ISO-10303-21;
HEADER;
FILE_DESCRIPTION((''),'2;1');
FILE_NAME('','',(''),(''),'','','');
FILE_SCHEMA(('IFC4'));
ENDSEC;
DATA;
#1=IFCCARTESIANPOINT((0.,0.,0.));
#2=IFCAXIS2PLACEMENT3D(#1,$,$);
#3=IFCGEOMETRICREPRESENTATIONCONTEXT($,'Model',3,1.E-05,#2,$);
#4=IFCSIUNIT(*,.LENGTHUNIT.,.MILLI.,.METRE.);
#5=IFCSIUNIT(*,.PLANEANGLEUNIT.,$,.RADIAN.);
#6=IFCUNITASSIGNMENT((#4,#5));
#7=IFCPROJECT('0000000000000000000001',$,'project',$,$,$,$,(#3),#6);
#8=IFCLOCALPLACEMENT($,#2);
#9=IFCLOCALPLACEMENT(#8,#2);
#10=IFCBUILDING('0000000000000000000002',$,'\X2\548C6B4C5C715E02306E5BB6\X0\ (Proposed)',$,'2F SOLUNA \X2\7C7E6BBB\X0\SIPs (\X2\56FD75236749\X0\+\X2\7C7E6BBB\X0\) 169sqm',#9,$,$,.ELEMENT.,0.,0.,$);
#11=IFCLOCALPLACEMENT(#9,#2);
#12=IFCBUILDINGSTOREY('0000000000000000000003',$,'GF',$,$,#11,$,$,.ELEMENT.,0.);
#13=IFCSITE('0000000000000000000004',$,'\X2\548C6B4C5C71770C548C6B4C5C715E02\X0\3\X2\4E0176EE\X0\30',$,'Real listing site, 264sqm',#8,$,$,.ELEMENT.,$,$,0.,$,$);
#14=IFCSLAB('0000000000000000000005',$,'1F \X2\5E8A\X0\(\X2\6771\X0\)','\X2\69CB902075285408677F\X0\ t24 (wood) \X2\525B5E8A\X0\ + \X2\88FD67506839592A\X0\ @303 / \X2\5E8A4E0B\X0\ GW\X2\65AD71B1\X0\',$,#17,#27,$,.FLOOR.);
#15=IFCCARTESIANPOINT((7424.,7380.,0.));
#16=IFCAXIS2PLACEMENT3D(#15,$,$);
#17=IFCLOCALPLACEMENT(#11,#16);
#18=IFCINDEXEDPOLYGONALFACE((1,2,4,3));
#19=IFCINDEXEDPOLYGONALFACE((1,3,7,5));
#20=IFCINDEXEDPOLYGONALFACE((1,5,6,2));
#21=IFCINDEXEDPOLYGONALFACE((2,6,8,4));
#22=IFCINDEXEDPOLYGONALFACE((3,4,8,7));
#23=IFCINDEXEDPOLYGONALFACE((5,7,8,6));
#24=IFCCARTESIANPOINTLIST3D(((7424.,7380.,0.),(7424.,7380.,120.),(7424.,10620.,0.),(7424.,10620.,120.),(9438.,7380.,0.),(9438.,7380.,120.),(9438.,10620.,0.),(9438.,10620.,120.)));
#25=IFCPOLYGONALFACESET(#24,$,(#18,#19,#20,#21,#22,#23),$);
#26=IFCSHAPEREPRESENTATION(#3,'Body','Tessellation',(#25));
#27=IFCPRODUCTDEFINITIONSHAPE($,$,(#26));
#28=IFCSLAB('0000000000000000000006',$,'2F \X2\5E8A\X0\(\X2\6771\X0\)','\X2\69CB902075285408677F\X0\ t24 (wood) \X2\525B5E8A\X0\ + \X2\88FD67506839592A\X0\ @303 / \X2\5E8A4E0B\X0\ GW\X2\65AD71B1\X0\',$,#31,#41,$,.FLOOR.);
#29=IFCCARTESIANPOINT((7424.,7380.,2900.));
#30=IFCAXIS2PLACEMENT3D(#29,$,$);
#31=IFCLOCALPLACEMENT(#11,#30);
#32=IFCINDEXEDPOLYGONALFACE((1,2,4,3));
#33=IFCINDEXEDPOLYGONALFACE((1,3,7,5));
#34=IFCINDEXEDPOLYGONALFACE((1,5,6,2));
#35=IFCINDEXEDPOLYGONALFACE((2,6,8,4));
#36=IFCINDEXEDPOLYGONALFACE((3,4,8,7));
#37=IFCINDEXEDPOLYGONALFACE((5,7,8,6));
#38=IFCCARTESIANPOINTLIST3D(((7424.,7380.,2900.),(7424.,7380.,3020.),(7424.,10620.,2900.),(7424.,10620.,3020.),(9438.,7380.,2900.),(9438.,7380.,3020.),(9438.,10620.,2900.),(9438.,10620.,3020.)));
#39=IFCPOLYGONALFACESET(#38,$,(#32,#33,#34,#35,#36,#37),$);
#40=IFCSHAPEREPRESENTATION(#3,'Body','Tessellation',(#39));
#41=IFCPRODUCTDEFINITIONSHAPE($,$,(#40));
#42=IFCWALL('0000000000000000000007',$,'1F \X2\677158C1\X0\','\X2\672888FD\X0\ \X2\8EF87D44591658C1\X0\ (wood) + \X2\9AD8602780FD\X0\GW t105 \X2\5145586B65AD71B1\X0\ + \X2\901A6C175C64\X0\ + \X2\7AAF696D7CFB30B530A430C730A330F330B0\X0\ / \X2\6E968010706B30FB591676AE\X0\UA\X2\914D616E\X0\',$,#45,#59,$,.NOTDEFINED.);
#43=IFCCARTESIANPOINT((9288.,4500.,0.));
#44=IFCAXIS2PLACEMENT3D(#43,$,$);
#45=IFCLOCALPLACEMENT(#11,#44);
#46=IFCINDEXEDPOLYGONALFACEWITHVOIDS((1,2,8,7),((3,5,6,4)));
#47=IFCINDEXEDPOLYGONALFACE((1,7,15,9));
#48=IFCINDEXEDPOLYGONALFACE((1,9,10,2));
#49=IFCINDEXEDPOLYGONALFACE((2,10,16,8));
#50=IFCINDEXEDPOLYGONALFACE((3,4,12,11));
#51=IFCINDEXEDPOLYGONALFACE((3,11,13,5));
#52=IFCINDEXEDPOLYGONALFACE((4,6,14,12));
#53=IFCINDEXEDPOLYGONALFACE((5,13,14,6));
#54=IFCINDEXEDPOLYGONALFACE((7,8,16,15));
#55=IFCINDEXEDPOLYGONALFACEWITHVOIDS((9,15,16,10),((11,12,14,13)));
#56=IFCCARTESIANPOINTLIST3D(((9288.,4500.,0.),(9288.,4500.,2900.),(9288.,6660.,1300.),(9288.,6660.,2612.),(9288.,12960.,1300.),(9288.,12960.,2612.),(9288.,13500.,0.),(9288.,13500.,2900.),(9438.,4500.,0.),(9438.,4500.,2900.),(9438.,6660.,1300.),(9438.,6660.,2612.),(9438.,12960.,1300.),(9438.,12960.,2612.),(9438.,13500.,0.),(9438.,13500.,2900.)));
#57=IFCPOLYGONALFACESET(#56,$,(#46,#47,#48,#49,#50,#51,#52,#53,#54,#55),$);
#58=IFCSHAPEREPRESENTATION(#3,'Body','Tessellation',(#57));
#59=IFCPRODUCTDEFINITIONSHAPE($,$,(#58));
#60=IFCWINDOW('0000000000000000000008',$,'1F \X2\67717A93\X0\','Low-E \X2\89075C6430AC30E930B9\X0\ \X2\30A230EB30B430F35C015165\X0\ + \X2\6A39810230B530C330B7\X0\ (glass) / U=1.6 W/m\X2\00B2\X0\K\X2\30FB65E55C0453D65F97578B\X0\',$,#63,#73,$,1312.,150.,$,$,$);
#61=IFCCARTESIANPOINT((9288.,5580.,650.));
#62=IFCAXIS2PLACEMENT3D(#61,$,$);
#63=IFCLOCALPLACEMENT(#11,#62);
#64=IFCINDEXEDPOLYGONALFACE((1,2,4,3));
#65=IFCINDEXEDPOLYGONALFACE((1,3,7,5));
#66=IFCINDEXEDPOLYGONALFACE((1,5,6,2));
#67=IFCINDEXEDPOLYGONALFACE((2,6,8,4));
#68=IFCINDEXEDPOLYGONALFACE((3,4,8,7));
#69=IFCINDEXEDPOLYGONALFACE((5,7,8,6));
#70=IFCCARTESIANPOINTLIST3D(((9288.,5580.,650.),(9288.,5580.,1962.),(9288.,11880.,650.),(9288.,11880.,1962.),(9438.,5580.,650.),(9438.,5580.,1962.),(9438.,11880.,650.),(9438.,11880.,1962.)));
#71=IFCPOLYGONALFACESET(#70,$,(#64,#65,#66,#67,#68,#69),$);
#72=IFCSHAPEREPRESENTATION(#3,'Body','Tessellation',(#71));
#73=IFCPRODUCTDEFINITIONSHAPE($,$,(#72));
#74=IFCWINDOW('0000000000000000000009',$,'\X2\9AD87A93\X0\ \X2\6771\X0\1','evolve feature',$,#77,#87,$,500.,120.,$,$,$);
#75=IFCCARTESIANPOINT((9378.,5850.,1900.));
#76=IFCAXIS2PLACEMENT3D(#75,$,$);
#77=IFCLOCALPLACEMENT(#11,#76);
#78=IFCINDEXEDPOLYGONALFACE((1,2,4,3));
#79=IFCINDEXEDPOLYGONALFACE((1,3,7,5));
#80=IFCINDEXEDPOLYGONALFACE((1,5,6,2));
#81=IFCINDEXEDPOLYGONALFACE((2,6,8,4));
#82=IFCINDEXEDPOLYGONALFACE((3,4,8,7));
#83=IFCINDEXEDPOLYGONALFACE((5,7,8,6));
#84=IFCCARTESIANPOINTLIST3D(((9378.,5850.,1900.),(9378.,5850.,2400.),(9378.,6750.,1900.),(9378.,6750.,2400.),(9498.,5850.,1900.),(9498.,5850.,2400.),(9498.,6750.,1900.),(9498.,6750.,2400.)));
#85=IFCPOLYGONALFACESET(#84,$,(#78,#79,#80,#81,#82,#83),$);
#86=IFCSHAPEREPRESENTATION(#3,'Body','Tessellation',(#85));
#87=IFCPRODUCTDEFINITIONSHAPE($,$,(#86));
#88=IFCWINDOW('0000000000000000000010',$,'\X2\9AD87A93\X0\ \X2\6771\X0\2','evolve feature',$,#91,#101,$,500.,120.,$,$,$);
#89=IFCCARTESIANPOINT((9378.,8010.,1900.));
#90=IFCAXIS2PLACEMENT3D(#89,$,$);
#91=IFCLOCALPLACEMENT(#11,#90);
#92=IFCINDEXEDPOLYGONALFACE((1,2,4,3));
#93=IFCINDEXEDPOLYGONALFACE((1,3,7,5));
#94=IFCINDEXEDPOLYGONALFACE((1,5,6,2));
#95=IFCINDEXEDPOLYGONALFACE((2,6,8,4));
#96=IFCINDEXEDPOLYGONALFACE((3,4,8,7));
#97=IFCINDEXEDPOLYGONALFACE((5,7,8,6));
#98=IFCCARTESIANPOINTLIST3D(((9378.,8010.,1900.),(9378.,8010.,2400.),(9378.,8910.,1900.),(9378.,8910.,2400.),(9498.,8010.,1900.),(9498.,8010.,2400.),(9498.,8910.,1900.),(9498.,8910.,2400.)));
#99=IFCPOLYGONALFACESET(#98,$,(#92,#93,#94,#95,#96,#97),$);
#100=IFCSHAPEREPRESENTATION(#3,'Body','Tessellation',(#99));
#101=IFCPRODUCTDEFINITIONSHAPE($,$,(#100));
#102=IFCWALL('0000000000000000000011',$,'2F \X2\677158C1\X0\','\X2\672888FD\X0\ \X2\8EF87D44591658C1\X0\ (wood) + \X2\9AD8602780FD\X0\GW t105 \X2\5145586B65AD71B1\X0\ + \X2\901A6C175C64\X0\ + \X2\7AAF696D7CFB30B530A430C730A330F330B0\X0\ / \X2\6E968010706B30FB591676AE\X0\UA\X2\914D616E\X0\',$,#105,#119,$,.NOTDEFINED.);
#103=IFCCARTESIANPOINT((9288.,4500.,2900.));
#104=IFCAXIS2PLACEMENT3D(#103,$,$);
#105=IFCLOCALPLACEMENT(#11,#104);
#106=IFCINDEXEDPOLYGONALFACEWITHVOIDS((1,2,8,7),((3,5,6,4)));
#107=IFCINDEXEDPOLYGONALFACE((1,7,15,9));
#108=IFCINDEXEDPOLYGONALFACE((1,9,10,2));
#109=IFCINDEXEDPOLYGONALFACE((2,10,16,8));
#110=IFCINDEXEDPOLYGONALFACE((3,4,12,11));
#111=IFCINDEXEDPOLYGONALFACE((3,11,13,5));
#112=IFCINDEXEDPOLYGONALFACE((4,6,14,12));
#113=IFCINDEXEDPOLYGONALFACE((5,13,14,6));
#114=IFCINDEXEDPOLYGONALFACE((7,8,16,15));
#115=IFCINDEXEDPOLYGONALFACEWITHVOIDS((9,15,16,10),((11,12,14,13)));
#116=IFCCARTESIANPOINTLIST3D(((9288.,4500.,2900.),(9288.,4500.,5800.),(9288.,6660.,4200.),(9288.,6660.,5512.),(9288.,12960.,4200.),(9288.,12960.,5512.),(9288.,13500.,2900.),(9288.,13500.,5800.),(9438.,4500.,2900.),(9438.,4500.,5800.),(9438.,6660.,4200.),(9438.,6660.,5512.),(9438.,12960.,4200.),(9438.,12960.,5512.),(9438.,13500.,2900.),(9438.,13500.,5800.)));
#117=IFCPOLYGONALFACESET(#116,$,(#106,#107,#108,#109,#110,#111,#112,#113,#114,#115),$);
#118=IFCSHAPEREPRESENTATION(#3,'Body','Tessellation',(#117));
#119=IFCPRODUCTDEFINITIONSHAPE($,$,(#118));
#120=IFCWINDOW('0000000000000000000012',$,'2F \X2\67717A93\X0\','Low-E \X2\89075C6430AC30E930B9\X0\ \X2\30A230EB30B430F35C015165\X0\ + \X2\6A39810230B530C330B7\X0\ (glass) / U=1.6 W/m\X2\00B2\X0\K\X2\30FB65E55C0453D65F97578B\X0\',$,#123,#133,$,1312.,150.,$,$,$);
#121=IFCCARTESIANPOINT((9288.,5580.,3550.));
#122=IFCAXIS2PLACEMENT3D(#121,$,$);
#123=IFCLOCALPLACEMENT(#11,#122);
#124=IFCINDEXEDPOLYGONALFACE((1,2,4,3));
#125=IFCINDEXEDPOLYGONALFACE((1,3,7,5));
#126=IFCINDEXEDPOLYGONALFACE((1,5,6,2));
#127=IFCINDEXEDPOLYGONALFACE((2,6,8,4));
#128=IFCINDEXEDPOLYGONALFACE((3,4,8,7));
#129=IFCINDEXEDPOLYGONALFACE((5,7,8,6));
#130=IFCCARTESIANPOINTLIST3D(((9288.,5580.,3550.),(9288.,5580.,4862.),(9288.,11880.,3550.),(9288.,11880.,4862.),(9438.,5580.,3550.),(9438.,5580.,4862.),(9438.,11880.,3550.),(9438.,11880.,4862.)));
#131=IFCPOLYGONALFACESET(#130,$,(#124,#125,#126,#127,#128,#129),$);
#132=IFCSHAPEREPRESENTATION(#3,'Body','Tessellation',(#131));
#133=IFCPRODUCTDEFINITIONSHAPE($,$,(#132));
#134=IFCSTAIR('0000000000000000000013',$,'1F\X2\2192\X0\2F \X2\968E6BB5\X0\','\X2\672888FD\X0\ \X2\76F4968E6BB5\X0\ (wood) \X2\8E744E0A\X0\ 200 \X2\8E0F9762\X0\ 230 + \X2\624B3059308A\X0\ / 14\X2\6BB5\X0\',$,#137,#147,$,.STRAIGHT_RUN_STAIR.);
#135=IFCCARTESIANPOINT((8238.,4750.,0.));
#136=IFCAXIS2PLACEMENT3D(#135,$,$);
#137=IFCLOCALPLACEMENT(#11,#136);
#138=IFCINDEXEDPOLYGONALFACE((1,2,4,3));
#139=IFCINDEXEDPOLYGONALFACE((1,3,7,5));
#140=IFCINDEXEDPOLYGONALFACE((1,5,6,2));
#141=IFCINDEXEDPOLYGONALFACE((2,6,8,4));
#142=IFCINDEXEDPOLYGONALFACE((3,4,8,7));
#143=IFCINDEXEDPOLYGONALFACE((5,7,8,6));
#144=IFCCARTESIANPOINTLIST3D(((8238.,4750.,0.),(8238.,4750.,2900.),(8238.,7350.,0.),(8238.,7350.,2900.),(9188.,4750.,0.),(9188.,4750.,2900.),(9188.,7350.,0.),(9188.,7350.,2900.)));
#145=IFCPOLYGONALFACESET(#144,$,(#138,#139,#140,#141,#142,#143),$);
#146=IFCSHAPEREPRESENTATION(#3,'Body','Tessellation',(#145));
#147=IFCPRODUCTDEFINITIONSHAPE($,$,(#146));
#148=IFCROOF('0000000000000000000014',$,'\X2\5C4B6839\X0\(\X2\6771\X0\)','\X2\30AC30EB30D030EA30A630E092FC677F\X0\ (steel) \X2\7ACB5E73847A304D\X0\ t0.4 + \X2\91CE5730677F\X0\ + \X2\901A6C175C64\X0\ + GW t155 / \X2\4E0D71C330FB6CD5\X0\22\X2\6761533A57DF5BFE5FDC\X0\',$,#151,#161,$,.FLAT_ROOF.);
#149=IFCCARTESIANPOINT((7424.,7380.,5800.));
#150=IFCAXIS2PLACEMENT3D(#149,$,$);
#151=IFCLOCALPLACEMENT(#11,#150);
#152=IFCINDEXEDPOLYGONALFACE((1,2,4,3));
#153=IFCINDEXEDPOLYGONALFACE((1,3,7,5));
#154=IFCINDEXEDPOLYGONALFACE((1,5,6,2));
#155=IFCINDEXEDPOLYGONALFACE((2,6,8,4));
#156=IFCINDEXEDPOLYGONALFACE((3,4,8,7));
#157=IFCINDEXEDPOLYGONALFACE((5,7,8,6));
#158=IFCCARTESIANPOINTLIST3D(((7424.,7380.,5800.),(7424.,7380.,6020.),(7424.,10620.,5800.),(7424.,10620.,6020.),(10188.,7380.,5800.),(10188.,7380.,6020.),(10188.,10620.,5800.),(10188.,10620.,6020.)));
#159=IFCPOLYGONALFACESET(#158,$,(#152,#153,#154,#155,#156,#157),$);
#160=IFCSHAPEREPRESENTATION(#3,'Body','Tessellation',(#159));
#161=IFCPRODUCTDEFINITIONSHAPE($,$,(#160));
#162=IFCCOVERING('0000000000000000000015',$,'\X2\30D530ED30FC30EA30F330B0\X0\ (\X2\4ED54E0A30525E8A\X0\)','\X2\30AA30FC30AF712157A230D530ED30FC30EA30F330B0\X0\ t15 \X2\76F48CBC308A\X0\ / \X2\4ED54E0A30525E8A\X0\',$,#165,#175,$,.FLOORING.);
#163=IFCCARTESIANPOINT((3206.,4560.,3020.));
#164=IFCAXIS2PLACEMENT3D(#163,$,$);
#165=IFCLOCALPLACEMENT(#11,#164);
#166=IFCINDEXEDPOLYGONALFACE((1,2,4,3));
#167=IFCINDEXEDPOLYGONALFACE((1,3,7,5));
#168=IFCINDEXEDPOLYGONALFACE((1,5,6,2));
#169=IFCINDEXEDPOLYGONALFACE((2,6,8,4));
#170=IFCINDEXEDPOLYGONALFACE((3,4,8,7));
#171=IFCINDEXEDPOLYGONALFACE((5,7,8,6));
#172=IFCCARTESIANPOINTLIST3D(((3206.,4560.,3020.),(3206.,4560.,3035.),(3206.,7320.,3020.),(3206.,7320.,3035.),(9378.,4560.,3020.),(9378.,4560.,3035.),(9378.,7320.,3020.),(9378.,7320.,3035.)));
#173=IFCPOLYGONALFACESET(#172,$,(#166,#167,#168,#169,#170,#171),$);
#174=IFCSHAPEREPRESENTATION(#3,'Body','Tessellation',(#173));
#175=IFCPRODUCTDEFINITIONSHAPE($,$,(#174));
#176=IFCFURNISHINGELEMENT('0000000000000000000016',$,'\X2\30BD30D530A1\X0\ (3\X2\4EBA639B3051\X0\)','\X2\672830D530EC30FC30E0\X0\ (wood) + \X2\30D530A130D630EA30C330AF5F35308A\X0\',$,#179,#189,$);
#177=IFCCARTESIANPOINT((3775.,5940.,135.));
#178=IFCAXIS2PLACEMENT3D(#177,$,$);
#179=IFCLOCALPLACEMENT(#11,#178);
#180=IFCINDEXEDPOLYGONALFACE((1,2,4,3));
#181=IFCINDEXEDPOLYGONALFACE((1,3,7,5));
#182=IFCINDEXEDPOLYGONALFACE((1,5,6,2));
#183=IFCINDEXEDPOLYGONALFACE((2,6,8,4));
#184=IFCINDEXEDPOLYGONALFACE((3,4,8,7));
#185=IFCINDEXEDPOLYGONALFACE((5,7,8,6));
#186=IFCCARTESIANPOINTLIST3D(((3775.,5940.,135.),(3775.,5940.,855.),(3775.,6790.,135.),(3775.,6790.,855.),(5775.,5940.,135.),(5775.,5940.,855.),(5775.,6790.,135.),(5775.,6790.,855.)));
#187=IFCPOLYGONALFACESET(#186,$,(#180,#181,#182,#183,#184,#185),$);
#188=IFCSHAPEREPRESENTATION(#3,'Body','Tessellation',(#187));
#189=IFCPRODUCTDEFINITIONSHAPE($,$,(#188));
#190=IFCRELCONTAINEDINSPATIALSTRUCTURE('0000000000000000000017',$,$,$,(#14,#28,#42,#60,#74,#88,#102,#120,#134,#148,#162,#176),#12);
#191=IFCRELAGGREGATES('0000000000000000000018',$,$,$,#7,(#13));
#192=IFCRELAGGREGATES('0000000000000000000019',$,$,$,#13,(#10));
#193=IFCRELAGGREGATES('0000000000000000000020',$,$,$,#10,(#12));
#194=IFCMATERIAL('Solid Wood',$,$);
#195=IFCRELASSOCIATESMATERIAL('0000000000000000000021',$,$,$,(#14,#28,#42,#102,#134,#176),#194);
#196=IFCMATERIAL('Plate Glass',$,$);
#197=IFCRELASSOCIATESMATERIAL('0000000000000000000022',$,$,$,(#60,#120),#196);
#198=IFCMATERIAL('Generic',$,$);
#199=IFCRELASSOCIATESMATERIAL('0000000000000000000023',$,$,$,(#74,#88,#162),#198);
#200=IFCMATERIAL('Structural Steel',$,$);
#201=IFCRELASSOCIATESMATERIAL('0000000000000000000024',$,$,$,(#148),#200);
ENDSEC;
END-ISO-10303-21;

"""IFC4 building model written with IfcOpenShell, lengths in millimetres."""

from ifc_helpers import new_model, si_unit, frame, frame_2d, origin, place, context, project, spatial, rectangle, extrude, material, element, fill, save


model = new_model("IFC4")

# Units and contexts
model_context = context("Model", 3, precision=1e-05, world=origin())
ifc_project = project(units=[si_unit("LENGTHUNIT", "METRE", prefix="MILLI"), si_unit("PLANEANGLEUNIT", "RADIAN")], contexts=[model_context])

# Site, building, storey
site_placement = place(None, origin())
site = spatial("IfcSite", under=ifc_project, at=site_placement, Name="和歌山県和歌山市3丁目30", ObjectType="Real listing site, 264sqm", CompositionType="ELEMENT", RefElevation=0.0)
building_placement = place(site_placement, origin())
building = spatial("IfcBuilding", under=site, at=building_placement, Name="和歌山市の家 (Proposed)", ObjectType="2F SOLUNA 籾殻SIPs (国産杉+籾殻) 169sqm", CompositionType="ELEMENT", ElevationOfRefHeight=0.0, ElevationOfTerrain=0.0)
storey_placement = place(building_placement, origin())
storey = spatial("IfcBuildingStorey", under=building, at=storey_placement, Name="GF", CompositionType="ELEMENT", Elevation=0.0)

# Slabs
ifc_material_1 = material(Name="Solid Wood")
slab_1_placement = place(storey_placement, frame((7424.0, 7380.0, 0.0)))
element("IfcSlab", 1, at=slab_1_placement, inside=storey, material=ifc_material_1, Name="1F 床(東)", Description="構造用合板 t24 (wood) 剛床 + 製材根太 @303 / 床下 GW断熱", PredefinedType="FLOOR", context=model_context, shape_type="SweptSolid", body=[
    extrude(rectangle(XDim=2014.0, YDim=3240.0, at=frame_2d((1007.0, 1620.0))), frame((7424.0, 7380.0, 0.0)), (0.0, 0.0, 1.0), 120.0),
])
slab_2_placement = place(storey_placement, frame((7424.0, 7380.0, 2900.0)))
element("IfcSlab", 2, at=slab_2_placement, inside=storey, material=ifc_material_1, Name="2F 床(東)", Description="構造用合板 t24 (wood) 剛床 + 製材根太 @303 / 床下 GW断熱", PredefinedType="FLOOR", context=model_context, shape_type="SweptSolid", body=[
    extrude(rectangle(XDim=2014.0, YDim=3240.0, at=frame_2d((1007.0, 1620.0))), frame((7424.0, 7380.0, 2900.0)), (0.0, 0.0, 1.0), 120.0),
])

# Wall, openings, windows
wall_1_placement = place(storey_placement, frame((9288.0, 4500.0, 0.0)))
wall_1 = element("IfcWall", 3, at=wall_1_placement, inside=storey, material=ifc_material_1, Name="1F 東壁", Description="木製 軸組外壁 (wood) + 高性能GW t105 充填断熱 + 通気層 + 窯業系サイディング / 準耐火・外皮UA配慮", PredefinedType="NOTDEFINED", context=model_context, shape_type="SweptSolid", body=[
    extrude(rectangle(XDim=150.0, YDim=9000.0, at=frame_2d((75.0, 4500.0))), frame((9288.0, 4500.0, 0.0)), (0.0, 0.0, 1.0), 2900.0),
])
opening_1_placement = place(storey_placement, frame((9288.0, 5580.0, 650.0)))
opening_1 = element("IfcOpeningElement", 4, at=opening_1_placement, cuts=wall_1, PredefinedType="NOTDEFINED", context=model_context, shape_type="SweptSolid", body=[
    extrude(rectangle(XDim=150.0, YDim=6300.0, at=frame_2d((75.0, 3150.0))), frame((9288.0, 5580.0, 650.0)), (0.0, 0.0, 1.0), 1312.0),
])
opening_2_placement = place(storey_placement, frame((9378.0, 5850.0, 1900.0)))
opening_2 = element("IfcOpeningElement", 5, at=opening_2_placement, cuts=wall_1, PredefinedType="NOTDEFINED", context=model_context, shape_type="SweptSolid", body=[
    extrude(rectangle(XDim=120.0, YDim=900.0, at=frame_2d((60.0, 450.0))), frame((9378.0, 5850.0, 1900.0)), (0.0, 0.0, 1.0), 500.0),
])
opening_3_placement = place(storey_placement, frame((9378.0, 8010.0, 1900.0)))
opening_3 = element("IfcOpeningElement", 6, at=opening_3_placement, cuts=wall_1, PredefinedType="NOTDEFINED", context=model_context, shape_type="SweptSolid", body=[
    extrude(rectangle(XDim=120.0, YDim=900.0, at=frame_2d((60.0, 450.0))), frame((9378.0, 8010.0, 1900.0)), (0.0, 0.0, 1.0), 500.0),
])
ifc_material_2 = material(Name="Plate Glass")
window_1_placement = place(storey_placement, frame((9288.0, 5580.0, 650.0)))
window_1 = element("IfcWindow", 7, at=window_1_placement, inside=storey, material=ifc_material_2, Name="1F 東窓", Description="Low-E 複層ガラス アルゴン封入 + 樹脂サッシ (glass) / U=1.6 W/m²K・日射取得型", OverallHeight=1312.0, OverallWidth=150.0, context=model_context, shape_type="SweptSolid", body=[
    extrude(rectangle(XDim=150.0, YDim=6300.0, at=frame_2d((75.0, 3150.0))), frame((9288.0, 5580.0, 650.0)), (0.0, 0.0, 1.0), 1312.0),
])
fill(opening_1, window_1)
ifc_material_3 = material(Name="Generic")
window_2_placement = place(storey_placement, frame((9378.0, 5850.0, 1900.0)))
window_2 = element("IfcWindow", 8, at=window_2_placement, inside=storey, material=ifc_material_3, Name="高窓 東1", Description="evolve feature", OverallHeight=500.0, OverallWidth=120.0, context=model_context, shape_type="SweptSolid", body=[
    extrude(rectangle(XDim=120.0, YDim=900.0, at=frame_2d((60.0, 450.0))), frame((9378.0, 5850.0, 1900.0)), (0.0, 0.0, 1.0), 500.0),
])
fill(opening_2, window_2)
window_3_placement = place(storey_placement, frame((9378.0, 8010.0, 1900.0)))
window_3 = element("IfcWindow", 9, at=window_3_placement, inside=storey, material=ifc_material_3, Name="高窓 東2", Description="evolve feature", OverallHeight=500.0, OverallWidth=120.0, context=model_context, shape_type="SweptSolid", body=[
    extrude(rectangle(XDim=120.0, YDim=900.0, at=frame_2d((60.0, 450.0))), frame((9378.0, 8010.0, 1900.0)), (0.0, 0.0, 1.0), 500.0),
])
fill(opening_3, window_3)

# Wall, opening, window
wall_2_placement = place(storey_placement, frame((9288.0, 4500.0, 2900.0)))
wall_2 = element("IfcWall", 10, at=wall_2_placement, inside=storey, material=ifc_material_1, Name="2F 東壁", Description="木製 軸組外壁 (wood) + 高性能GW t105 充填断熱 + 通気層 + 窯業系サイディング / 準耐火・外皮UA配慮", PredefinedType="NOTDEFINED", context=model_context, shape_type="SweptSolid", body=[
    extrude(rectangle(XDim=150.0, YDim=9000.0, at=frame_2d((75.0, 4500.0))), frame((9288.0, 4500.0, 2900.0)), (0.0, 0.0, 1.0), 2900.0),
])
opening_4_placement = place(storey_placement, frame((9288.0, 5580.0, 3550.0)))
opening_4 = element("IfcOpeningElement", 11, at=opening_4_placement, cuts=wall_2, PredefinedType="NOTDEFINED", context=model_context, shape_type="SweptSolid", body=[
    extrude(rectangle(XDim=150.0, YDim=6300.0, at=frame_2d((75.0, 3150.0))), frame((9288.0, 5580.0, 3550.0)), (0.0, 0.0, 1.0), 1312.0),
])
window_4_placement = place(storey_placement, frame((9288.0, 5580.0, 3550.0)))
window_4 = element("IfcWindow", 12, at=window_4_placement, inside=storey, material=ifc_material_2, Name="2F 東窓", Description="Low-E 複層ガラス アルゴン封入 + 樹脂サッシ (glass) / U=1.6 W/m²K・日射取得型", OverallHeight=1312.0, OverallWidth=150.0, context=model_context, shape_type="SweptSolid", body=[
    extrude(rectangle(XDim=150.0, YDim=6300.0, at=frame_2d((75.0, 3150.0))), frame((9288.0, 5580.0, 3550.0)), (0.0, 0.0, 1.0), 1312.0),
])
fill(opening_4, window_4)

# Stair
stair_placement = place(storey_placement, frame((8238.0, 4750.0, 0.0)))
element("IfcStair", 13, at=stair_placement, inside=storey, material=ifc_material_1, Name="1F→2F 階段", Description="木製 直階段 (wood) 蹴上 200 踏面 230 + 手すり / 14段", PredefinedType="STRAIGHT_RUN_STAIR", context=model_context, shape_type="SweptSolid", body=[
    extrude(rectangle(XDim=950.0, YDim=2600.0, at=frame_2d((475.0, 1300.0))), frame((8238.0, 4750.0, 0.0)), (0.0, 0.0, 1.0), 2900.0),
])

# Roof
ifc_material_4 = material(Name="Structural Steel")
roof_placement = place(storey_placement, frame((7424.0, 7380.0, 5800.0)))
element("IfcRoof", 14, at=roof_placement, inside=storey, material=ifc_material_4, Name="屋根(東)", Description="ガルバリウム鋼板 (steel) 立平葺き t0.4 + 野地板 + 通気層 + GW t155 / 不燃・法22条区域対応", PredefinedType="FLAT_ROOF", context=model_context, shape_type="SweptSolid", body=[
    extrude(rectangle(XDim=2764.0, YDim=3240.0, at=frame_2d((1382.0, 1620.0))), frame((7424.0, 7380.0, 5800.0)), (0.0, 0.0, 1.0), 220.0),
])

# Covering
covering_placement = place(storey_placement, frame((3206.0, 4560.0, 3020.0)))
element("IfcCovering", 15, at=covering_placement, inside=storey, material=ifc_material_3, Name="フローリング (仕上げ床)", Description="オーク無垢フローリング t15 直貼り / 仕上げ床", PredefinedType="FLOORING", context=model_context, shape_type="SweptSolid", body=[
    extrude(rectangle(XDim=6172.0, YDim=2760.0, at=frame_2d((3086.0, 1380.0))), frame((3206.0, 4560.0, 3020.0)), (0.0, 0.0, 1.0), 15.0),
])

# Furnishing element
furnishing_1_placement = place(storey_placement, frame((3775.0, 5940.0, 135.0)))
element("IfcFurnishingElement", 16, at=furnishing_1_placement, inside=storey, material=ifc_material_1, Name="ソファ (3人掛け)", Description="木フレーム (wood) + ファブリック張り", context=model_context, shape_type="SweptSolid", body=[
    extrude(rectangle(XDim=2000.0, YDim=850.0, at=frame_2d((1000.0, 425.0))), frame((3775.0, 5940.0, 135.0)), (0.0, 0.0, 1.0), 720.0),
])

save(model, "model.ifc")
